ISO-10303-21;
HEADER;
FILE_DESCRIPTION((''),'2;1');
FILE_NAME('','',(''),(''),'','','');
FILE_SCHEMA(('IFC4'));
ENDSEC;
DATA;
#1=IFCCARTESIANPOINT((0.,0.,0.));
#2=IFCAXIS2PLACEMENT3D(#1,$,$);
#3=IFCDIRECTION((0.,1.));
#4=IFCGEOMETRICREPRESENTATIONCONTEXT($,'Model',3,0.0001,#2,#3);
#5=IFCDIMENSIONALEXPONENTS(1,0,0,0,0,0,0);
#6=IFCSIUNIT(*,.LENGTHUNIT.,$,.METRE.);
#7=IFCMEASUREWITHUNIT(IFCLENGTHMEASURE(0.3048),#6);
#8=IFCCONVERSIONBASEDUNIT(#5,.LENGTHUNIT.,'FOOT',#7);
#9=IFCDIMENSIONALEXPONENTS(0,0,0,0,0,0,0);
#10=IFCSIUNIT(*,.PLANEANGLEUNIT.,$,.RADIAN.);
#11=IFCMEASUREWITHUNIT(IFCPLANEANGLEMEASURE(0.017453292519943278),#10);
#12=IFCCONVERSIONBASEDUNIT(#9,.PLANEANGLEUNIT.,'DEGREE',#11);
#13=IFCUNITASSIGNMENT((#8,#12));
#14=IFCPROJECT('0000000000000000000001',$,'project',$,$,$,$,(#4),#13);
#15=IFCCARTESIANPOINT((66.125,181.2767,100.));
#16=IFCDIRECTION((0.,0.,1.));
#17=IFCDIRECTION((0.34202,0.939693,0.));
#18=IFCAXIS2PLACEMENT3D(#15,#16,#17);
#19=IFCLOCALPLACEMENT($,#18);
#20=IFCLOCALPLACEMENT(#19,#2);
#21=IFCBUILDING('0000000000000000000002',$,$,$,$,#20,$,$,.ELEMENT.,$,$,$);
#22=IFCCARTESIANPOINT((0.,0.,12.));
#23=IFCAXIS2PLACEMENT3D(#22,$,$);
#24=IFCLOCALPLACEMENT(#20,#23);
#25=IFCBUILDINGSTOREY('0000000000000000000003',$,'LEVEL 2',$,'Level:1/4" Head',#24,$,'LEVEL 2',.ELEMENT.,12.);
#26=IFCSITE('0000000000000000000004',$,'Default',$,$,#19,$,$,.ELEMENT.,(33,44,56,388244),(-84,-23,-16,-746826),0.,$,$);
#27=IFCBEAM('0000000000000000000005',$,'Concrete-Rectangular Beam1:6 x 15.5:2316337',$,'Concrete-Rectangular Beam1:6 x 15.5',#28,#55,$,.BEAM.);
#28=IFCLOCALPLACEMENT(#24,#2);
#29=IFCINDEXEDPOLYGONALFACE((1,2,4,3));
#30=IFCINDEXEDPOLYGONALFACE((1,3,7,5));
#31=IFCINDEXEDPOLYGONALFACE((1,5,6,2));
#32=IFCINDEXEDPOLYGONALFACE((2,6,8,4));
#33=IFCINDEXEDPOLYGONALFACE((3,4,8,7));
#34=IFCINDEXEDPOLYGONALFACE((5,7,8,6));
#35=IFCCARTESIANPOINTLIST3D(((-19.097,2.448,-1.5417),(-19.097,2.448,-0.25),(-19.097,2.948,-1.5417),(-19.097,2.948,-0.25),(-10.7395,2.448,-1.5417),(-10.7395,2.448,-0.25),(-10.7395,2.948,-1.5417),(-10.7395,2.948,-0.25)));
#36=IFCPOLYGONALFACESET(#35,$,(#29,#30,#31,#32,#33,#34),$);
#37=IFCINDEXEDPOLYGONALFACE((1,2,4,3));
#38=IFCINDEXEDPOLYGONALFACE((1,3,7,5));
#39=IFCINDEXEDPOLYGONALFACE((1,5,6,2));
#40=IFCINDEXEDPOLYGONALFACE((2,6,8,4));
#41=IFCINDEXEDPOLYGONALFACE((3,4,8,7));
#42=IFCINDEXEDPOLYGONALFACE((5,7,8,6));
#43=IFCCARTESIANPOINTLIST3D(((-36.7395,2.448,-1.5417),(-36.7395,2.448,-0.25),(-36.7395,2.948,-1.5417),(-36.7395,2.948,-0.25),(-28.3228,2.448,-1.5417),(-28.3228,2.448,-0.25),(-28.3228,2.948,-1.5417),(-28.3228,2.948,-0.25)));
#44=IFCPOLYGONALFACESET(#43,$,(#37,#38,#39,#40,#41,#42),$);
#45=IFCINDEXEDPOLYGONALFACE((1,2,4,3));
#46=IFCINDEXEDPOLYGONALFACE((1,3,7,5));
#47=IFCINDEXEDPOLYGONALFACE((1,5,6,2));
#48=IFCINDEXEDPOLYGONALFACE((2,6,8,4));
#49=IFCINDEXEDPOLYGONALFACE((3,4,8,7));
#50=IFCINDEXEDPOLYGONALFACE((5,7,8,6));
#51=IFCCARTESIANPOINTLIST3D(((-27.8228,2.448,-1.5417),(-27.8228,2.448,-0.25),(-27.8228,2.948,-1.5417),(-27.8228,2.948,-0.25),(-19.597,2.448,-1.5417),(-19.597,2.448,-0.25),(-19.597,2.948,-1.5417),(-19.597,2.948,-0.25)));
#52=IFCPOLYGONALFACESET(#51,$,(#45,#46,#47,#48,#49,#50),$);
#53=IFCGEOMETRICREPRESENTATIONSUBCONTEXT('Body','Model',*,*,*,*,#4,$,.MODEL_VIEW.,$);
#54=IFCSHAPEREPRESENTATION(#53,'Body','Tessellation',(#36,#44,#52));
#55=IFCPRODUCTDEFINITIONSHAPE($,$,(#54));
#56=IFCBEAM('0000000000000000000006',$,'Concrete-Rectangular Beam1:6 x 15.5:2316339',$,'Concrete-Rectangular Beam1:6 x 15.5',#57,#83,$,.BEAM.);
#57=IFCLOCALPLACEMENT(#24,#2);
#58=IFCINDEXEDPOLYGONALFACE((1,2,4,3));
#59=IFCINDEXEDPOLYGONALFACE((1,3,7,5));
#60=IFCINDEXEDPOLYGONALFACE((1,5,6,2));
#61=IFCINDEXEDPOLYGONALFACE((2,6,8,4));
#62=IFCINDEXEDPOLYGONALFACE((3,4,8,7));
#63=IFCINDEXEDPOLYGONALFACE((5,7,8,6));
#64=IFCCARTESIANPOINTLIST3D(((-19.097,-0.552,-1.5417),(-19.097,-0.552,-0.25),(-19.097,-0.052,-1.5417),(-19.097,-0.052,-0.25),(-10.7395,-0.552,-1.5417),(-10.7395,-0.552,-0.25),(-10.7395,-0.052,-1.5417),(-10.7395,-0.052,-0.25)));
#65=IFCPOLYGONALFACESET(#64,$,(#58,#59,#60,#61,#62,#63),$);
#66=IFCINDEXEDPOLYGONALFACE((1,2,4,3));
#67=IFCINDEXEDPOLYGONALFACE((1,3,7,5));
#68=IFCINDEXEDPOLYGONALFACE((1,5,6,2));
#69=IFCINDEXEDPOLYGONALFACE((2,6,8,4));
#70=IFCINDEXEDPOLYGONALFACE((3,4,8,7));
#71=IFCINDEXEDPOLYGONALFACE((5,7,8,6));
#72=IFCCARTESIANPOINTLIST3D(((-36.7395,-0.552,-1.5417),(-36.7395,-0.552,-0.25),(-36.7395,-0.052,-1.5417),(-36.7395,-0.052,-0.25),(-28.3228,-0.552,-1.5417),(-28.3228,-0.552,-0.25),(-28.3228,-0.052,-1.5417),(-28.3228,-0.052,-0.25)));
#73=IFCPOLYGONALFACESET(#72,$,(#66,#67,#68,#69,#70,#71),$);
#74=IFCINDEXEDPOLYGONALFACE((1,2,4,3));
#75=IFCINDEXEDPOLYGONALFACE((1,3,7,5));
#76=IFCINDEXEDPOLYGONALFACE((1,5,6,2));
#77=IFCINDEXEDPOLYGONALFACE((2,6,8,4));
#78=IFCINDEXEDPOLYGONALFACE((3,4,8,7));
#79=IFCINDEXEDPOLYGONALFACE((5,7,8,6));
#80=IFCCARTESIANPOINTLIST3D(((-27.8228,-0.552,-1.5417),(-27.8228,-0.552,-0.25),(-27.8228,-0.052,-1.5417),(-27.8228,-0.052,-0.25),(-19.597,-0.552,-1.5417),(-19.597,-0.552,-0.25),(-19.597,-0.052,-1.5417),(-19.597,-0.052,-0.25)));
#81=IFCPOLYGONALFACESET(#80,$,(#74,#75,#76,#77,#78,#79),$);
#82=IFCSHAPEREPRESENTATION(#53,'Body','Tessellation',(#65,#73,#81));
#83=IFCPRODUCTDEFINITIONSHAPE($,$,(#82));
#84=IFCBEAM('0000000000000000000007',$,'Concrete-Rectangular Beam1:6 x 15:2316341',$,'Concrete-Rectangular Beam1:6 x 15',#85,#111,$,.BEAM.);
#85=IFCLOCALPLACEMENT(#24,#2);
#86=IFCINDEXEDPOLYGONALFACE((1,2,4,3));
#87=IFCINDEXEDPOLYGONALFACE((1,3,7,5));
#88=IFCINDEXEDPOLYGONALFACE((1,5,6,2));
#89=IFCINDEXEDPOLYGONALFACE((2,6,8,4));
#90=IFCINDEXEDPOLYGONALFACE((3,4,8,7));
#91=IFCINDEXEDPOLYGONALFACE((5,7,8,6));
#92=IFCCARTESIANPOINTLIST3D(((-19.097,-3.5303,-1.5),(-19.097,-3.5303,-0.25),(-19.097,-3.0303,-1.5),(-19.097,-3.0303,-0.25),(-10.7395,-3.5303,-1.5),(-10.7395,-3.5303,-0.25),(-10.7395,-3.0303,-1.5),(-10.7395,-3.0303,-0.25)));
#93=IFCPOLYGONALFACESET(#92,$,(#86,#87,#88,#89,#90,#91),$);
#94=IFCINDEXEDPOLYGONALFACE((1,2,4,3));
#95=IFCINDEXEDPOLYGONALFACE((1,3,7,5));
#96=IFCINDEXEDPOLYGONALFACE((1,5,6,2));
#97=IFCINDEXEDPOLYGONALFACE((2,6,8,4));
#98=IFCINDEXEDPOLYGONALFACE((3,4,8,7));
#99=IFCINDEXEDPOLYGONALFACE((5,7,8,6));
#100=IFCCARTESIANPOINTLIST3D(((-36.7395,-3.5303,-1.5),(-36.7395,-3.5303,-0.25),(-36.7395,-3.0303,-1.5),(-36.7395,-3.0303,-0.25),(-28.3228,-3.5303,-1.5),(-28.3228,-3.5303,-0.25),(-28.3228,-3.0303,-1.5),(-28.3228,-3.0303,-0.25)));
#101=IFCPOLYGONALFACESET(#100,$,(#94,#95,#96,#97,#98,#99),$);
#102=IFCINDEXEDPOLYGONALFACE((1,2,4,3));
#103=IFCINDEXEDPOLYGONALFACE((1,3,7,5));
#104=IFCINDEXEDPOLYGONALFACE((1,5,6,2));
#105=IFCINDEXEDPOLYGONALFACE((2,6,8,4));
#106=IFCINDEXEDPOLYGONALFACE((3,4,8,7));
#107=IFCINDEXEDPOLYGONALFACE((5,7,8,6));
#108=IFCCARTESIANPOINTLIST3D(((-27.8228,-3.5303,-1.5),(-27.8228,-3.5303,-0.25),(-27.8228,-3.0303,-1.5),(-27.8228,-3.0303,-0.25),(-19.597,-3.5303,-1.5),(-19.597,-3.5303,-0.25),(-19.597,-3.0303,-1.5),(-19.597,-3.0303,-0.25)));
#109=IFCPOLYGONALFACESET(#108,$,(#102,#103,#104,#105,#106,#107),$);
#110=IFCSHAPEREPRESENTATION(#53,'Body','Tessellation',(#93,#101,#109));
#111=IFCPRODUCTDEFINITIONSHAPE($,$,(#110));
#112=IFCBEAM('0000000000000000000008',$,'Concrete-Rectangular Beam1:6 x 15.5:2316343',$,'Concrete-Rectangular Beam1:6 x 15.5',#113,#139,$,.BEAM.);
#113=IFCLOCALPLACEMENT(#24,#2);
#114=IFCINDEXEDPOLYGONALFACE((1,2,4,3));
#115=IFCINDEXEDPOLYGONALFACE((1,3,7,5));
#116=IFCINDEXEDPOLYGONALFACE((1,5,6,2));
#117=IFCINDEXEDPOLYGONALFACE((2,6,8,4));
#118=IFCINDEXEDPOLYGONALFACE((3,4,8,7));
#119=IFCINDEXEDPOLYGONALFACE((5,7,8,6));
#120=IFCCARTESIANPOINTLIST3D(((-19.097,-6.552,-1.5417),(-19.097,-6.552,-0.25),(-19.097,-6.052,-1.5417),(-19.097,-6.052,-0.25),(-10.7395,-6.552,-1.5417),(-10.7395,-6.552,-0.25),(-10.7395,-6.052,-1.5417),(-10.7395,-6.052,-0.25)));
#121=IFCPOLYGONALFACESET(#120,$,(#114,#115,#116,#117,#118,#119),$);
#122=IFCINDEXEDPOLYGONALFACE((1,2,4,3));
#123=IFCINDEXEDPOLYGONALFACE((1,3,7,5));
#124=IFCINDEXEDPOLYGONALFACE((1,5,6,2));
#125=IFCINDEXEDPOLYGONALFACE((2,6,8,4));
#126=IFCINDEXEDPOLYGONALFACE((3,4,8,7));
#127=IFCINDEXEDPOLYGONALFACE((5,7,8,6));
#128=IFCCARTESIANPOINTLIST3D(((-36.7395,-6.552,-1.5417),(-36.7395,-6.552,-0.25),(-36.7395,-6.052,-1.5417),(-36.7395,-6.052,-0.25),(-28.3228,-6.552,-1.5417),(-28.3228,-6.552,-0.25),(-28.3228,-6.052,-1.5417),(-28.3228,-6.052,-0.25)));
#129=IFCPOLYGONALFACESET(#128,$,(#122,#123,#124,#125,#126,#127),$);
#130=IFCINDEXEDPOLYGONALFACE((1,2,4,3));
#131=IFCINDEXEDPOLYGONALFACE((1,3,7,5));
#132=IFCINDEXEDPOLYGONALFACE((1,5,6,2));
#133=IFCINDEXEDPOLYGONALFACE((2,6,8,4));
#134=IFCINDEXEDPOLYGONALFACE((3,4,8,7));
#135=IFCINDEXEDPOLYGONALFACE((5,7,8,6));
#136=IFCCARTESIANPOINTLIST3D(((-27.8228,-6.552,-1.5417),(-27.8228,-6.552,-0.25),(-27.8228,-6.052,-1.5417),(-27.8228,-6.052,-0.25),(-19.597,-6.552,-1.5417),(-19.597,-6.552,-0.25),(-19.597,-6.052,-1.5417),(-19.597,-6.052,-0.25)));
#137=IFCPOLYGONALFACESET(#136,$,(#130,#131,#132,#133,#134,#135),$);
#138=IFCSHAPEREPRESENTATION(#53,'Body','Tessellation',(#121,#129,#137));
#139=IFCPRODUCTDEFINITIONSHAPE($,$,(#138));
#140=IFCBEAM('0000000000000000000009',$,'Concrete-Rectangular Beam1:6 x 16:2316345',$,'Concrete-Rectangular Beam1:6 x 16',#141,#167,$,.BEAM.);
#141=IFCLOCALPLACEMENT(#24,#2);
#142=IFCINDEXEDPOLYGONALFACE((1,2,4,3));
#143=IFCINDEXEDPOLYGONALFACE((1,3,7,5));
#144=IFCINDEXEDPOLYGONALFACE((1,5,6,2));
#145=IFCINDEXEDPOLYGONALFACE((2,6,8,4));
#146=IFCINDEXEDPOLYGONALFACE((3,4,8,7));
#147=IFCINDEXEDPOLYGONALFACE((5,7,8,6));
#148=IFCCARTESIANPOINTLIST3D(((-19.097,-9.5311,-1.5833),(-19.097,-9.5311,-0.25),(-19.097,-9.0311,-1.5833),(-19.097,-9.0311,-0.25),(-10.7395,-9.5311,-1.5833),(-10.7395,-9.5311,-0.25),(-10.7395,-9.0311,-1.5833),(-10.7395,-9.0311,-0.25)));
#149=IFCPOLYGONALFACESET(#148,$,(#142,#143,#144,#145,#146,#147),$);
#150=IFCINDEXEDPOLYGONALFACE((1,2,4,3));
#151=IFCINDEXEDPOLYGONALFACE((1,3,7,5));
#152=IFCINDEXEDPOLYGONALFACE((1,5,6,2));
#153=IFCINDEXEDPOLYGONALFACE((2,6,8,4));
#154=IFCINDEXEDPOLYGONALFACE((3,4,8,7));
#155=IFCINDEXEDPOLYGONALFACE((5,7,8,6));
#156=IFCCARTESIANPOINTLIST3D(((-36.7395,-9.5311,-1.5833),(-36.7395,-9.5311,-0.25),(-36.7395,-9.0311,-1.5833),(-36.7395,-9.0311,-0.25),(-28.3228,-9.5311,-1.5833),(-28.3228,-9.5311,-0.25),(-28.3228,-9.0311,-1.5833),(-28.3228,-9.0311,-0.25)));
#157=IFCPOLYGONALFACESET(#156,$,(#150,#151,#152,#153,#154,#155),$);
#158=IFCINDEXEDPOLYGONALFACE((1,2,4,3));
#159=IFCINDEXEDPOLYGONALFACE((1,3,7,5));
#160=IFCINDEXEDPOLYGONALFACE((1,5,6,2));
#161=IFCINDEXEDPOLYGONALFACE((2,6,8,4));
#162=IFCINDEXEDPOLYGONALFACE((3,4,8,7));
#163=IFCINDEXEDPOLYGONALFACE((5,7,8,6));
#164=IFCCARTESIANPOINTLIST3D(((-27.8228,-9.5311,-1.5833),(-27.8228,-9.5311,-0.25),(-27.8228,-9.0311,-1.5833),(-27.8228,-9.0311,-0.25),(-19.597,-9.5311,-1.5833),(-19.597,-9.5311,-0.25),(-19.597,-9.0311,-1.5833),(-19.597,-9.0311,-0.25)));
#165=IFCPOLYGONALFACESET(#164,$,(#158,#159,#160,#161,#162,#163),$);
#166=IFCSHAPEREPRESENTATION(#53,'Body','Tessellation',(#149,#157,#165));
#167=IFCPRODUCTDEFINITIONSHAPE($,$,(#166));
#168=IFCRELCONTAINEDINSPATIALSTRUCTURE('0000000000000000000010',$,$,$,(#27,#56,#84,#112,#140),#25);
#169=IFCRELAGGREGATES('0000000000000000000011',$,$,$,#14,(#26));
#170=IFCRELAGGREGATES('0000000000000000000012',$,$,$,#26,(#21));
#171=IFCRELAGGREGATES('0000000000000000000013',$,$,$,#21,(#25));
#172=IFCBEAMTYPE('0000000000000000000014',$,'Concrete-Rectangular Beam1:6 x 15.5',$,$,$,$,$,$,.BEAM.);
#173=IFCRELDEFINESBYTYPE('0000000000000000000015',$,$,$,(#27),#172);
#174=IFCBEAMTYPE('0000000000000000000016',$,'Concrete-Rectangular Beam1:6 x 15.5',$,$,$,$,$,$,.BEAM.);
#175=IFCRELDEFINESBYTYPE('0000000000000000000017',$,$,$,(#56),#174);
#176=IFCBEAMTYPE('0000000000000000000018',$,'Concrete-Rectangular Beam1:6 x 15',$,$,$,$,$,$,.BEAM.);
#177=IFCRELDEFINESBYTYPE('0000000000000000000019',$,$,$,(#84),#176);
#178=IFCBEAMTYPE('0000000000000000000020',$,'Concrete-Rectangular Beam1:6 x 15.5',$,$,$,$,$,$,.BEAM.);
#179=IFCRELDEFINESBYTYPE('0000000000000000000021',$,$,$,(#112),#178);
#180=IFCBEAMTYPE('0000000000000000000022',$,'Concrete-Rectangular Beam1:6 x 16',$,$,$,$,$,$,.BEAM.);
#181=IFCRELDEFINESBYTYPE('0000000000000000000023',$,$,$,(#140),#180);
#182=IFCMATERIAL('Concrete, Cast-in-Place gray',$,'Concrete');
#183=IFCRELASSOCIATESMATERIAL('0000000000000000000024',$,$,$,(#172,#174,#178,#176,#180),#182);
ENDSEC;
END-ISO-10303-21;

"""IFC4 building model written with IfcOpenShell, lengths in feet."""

from ifc_helpers import new_model, entity, si_unit, converted_unit, direction, frame, frame_2d, origin, origin_2d_with_axis, place, context, subcontext, project, spatial, polyline, segment, composite_curve, rectangle, outline, extrude, source, transform, mapped, material, material_profile, profile_set, type_object, type_shapes, element, save


model = new_model("IFC4")

# Units and contexts
model_context = context("Model", 3, precision=0.0001, world=origin(), true_north=direction((0.0, 1.0)))
body_context = subcontext(model_context, "Body", "Model", "MODEL_VIEW")
ifc_project = project(units=[converted_unit("LENGTHUNIT", "FOOT", entity("IfcLengthMeasure", 0.3048), si_unit("LENGTHUNIT", "METRE"), dimensions=[1, 0, 0, 0, 0, 0, 0]), converted_unit("PLANEANGLEUNIT", "DEGREE", entity("IfcPlaneAngleMeasure", 0.017453292519943278), si_unit("PLANEANGLEUNIT", "RADIAN"), dimensions=[0, 0, 0, 0, 0, 0, 0])], contexts=[model_context])

# Site, building, storey
site_placement = place(None, frame((66.125, 181.2767, 100.0), z_axis=(0.0, 0.0, 1.0), x_axis=(0.34202, 0.939693, 0.0)))
site = spatial("IfcSite", under=ifc_project, at=site_placement, Name="Default", CompositionType="ELEMENT", RefLatitude=(33, 44, 56, 388244), RefLongitude=(-84, -23, -16, -746826), RefElevation=0.0)
building_placement = place(site_placement, origin())
building = spatial("IfcBuilding", under=site, at=building_placement, CompositionType="ELEMENT")
storey_placement = place(building_placement, frame((0.0, 0.0, 12.0)))
storey = spatial("IfcBuildingStorey", under=building, at=storey_placement, Name="LEVEL 2", ObjectType="Level:1/4\" Head", LongName="LEVEL 2", CompositionType="ELEMENT", Elevation=12.0)

# Beams
ifc_material = material(Name="Concrete, Cast-in-Place gray", Category="Concrete")
ifc_material_profile_1 = material_profile(ifc_material, rectangle(XDim=1.3333, YDim=0.5, at=frame_2d((0.0, 0.0), x_axis=(1.0, 0.0))), Name="6 x 16")
ifc_profile_set_1 = profile_set([ifc_material_profile_1], Name="6 x 16")
ifc_material_profile_2 = material_profile(ifc_material, outline(composite_curve([segment(polyline([(-0.25, 0.6458, 0.0), (0.25, 0.6458, 0.0)]), True, "CONTINUOUS"), segment(polyline([(0.25, 0.6458, 0.0), (0.25, -0.6458, 0.0)]), True, "CONTINUOUS"), segment(polyline([(0.25, -0.6458, 0.0), (-0.25, -0.6458, 0.0)]), True, "CONTINUOUS"), segment(polyline([(-0.25, -0.6458, 0.0), (-0.25, 0.6458, 0.0)]), True, "CONTINUOUS")], self_intersect=False), kind="CURVE"), Name="6 x 15.5")
ifc_material_profile_3 = material_profile(ifc_material, outline(composite_curve([segment(polyline([(-12.5417, 0.25, 0.6458), (-12.5417, 0.25, -0.6458)]), True, "CONTINUOUS"), segment(polyline([(-12.5417, 0.25, -0.6458), (-12.5417, -0.25, -0.6458)]), True, "CONTINUOUS"), segment(polyline([(-12.5417, -0.25, -0.6458), (-12.5417, -0.25, 0.6458)]), True, "CONTINUOUS"), segment(polyline([(-12.5417, -0.25, 0.6458), (-12.5417, 0.25, 0.6458)]), True, "CONTINUOUS")], self_intersect=False), kind="CURVE"), Name="6 x 15.5")
ifc_profile_set_2 = profile_set([ifc_material_profile_2, ifc_material_profile_3], Name="6 x 15.5")
beam_type_1 = type_object("IfcBeamType", Name="Concrete-Rectangular Beam1:6 x 15.5", PredefinedType="BEAM", material=ifc_profile_set_2)
shared_shape_1 = source(origin(), body_context, "Body", "SweptSolid", [
    extrude(rectangle(XDim=1.2917, YDim=0.5, at=frame_2d((0.0, 0.0), x_axis=(1.0, 0.0))), frame((-19.097, 2.698, 11.1042), z_axis=(1.0, 0.0, 0.0), x_axis=(0.0, 0.0, -1.0)), (0.0, 0.0, 1.0), 8.3575),
    extrude(rectangle(XDim=1.2917, YDim=0.5, at=frame_2d((0.0, 0.0), x_axis=(1.0, 0.0))), frame((-36.7395, 2.698, 11.1042), z_axis=(1.0, 0.0, 0.0), x_axis=(0.0, 0.0, -1.0)), (0.0, 0.0, 1.0), 8.4167),
    extrude(rectangle(XDim=1.2917, YDim=0.5, at=frame_2d((0.0, 0.0), x_axis=(1.0, 0.0))), frame((-27.8228, 2.698, 11.1042), z_axis=(1.0, 0.0, 0.0), x_axis=(0.0, 0.0, -1.0)), (0.0, 0.0, 1.0), 8.2258),
])
type_shapes(beam_type_1, [shared_shape_1])
beam_1_placement = place(storey_placement, frame((0.0, 0.0, -12.0)))
element("IfcBeam", 1, at=beam_1_placement, inside=storey, type_object=beam_type_1, Name="Concrete-Rectangular Beam1:6 x 15.5:2316337", ObjectType="Concrete-Rectangular Beam1:6 x 15.5", PredefinedType="BEAM", context=body_context, shape_type="MappedRepresentation", body=[
    mapped(shared_shape_1, transform((0.0, 0.0, 0.0), scale=1.0)),
])
beam_type_2 = type_object("IfcBeamType", Name="Concrete-Rectangular Beam1:6 x 15.5", PredefinedType="BEAM", material=ifc_profile_set_2)
shared_shape_2 = source(origin(), body_context, "Body", "SweptSolid", [
    extrude(rectangle(XDim=1.2917, YDim=0.5, at=frame_2d((0.0, 0.0), x_axis=(1.0, 0.0))), frame((-19.097, -0.302, 11.1042), z_axis=(1.0, 0.0, 0.0), x_axis=(0.0, 0.0, -1.0)), (0.0, 0.0, 1.0), 8.3575),
    extrude(rectangle(XDim=1.2917, YDim=0.5, at=frame_2d((0.0, 0.0), x_axis=(1.0, 0.0))), frame((-36.7395, -0.302, 11.1042), z_axis=(1.0, 0.0, 0.0), x_axis=(0.0, 0.0, -1.0)), (0.0, 0.0, 1.0), 8.4167),
    extrude(rectangle(XDim=1.2917, YDim=0.5, at=frame_2d((0.0, 0.0), x_axis=(1.0, 0.0))), frame((-27.8228, -0.302, 11.1042), z_axis=(1.0, 0.0, 0.0), x_axis=(0.0, 0.0, -1.0)), (0.0, 0.0, 1.0), 8.2258),
])
type_shapes(beam_type_2, [shared_shape_2])
beam_2_placement = place(storey_placement, frame((0.0, 0.0, -12.0)))
element("IfcBeam", 2, at=beam_2_placement, inside=storey, type_object=beam_type_2, Name="Concrete-Rectangular Beam1:6 x 15.5:2316339", ObjectType="Concrete-Rectangular Beam1:6 x 15.5", PredefinedType="BEAM", context=body_context, shape_type="MappedRepresentation", body=[
    mapped(shared_shape_2, transform((0.0, 0.0, 0.0), scale=1.0)),
])
ifc_material_profile_4 = material_profile(ifc_material, rectangle(XDim=1.25, YDim=0.5, at=origin_2d_with_axis()), Name="6 x 15")
ifc_profile_set_3 = profile_set([ifc_material_profile_4], Name="6 x 15")
beam_type_3 = type_object("IfcBeamType", Name="Concrete-Rectangular Beam1:6 x 15", PredefinedType="BEAM", material=ifc_profile_set_3)
shared_shape_3 = source(origin(), body_context, "Body", "SweptSolid", [
    extrude(rectangle(XDim=1.25, YDim=0.5, at=origin_2d_with_axis()), frame((-19.097, -3.2803, 11.125), z_axis=(1.0, 0.0, 0.0), x_axis=(0.0, 0.0, -1.0)), (0.0, 0.0, 1.0), 8.3575),
    extrude(rectangle(XDim=1.25, YDim=0.5, at=origin_2d_with_axis()), frame((-36.7395, -3.2803, 11.125), z_axis=(1.0, 0.0, 0.0), x_axis=(0.0, 0.0, -1.0)), (0.0, 0.0, 1.0), 8.4167),
    extrude(rectangle(XDim=1.25, YDim=0.5, at=origin_2d_with_axis()), frame((-27.8228, -3.2803, 11.125), z_axis=(1.0, 0.0, 0.0), x_axis=(0.0, 0.0, -1.0)), (0.0, 0.0, 1.0), 8.2258),
])
type_shapes(beam_type_3, [shared_shape_3])
beam_3_placement = place(storey_placement, frame((0.0, 0.0, -12.0)))
element("IfcBeam", 3, at=beam_3_placement, inside=storey, type_object=beam_type_3, Name="Concrete-Rectangular Beam1:6 x 15:2316341", ObjectType="Concrete-Rectangular Beam1:6 x 15", PredefinedType="BEAM", context=body_context, shape_type="MappedRepresentation", body=[
    mapped(shared_shape_3, transform((0.0, 0.0, 0.0), scale=1.0)),
])
beam_type_4 = type_object("IfcBeamType", Name="Concrete-Rectangular Beam1:6 x 15.5", PredefinedType="BEAM", material=ifc_profile_set_2)
shared_shape_4 = source(origin(), body_context, "Body", "SweptSolid", [
    extrude(rectangle(XDim=1.2917, YDim=0.5, at=frame_2d((0.0, 0.0), x_axis=(1.0, 0.0))), frame((-19.097, -6.302, 11.1042), z_axis=(1.0, 0.0, 0.0), x_axis=(0.0, 0.0, -1.0)), (0.0, 0.0, 1.0), 8.3575),
    extrude(rectangle(XDim=1.2917, YDim=0.5, at=frame_2d((0.0, 0.0), x_axis=(1.0, 0.0))), frame((-36.7395, -6.302, 11.1042), z_axis=(1.0, 0.0, 0.0), x_axis=(0.0, 0.0, -1.0)), (0.0, 0.0, 1.0), 8.4167),
    extrude(rectangle(XDim=1.2917, YDim=0.5, at=frame_2d((0.0, 0.0), x_axis=(1.0, 0.0))), frame((-27.8228, -6.302, 11.1042), z_axis=(1.0, 0.0, 0.0), x_axis=(0.0, 0.0, -1.0)), (0.0, 0.0, 1.0), 8.2258),
])
type_shapes(beam_type_4, [shared_shape_4])
beam_4_placement = place(storey_placement, frame((0.0, 0.0, -12.0)))
element("IfcBeam", 4, at=beam_4_placement, inside=storey, type_object=beam_type_4, Name="Concrete-Rectangular Beam1:6 x 15.5:2316343", ObjectType="Concrete-Rectangular Beam1:6 x 15.5", PredefinedType="BEAM", context=body_context, shape_type="MappedRepresentation", body=[
    mapped(shared_shape_4, transform((0.0, 0.0, 0.0), scale=1.0)),
])
beam_type_5 = type_object("IfcBeamType", Name="Concrete-Rectangular Beam1:6 x 16", PredefinedType="BEAM", material=ifc_profile_set_1)
shared_shape_5 = source(origin(), body_context, "Body", "SweptSolid", [
    extrude(rectangle(XDim=1.3333, YDim=0.5, at=frame_2d((0.0, 0.0), x_axis=(1.0, 0.0))), frame((-19.097, -9.2811, 11.0833), z_axis=(1.0, 0.0, 0.0), x_axis=(0.0, 0.0, -1.0)), (0.0, 0.0, 1.0), 8.3575),
    extrude(rectangle(XDim=1.3333, YDim=0.5, at=frame_2d((0.0, 0.0), x_axis=(1.0, 0.0))), frame((-36.7395, -9.2811, 11.0833), z_axis=(1.0, 0.0, 0.0), x_axis=(0.0, 0.0, -1.0)), (0.0, 0.0, 1.0), 8.4167),
    extrude(rectangle(XDim=1.3333, YDim=0.5, at=frame_2d((0.0, 0.0), x_axis=(1.0, 0.0))), frame((-27.8228, -9.2811, 11.0833), z_axis=(1.0, 0.0, 0.0), x_axis=(0.0, 0.0, -1.0)), (0.0, 0.0, 1.0), 8.2258),
])
type_shapes(beam_type_5, [shared_shape_5])
beam_5_placement = place(storey_placement, frame((0.0, 0.0, -12.0)))
element("IfcBeam", 5, at=beam_5_placement, inside=storey, type_object=beam_type_5, Name="Concrete-Rectangular Beam1:6 x 16:2316345", ObjectType="Concrete-Rectangular Beam1:6 x 16", PredefinedType="BEAM", context=body_context, shape_type="MappedRepresentation", body=[
    mapped(shared_shape_5, transform((0.0, 0.0, 0.0), scale=1.0)),
])

save(model, "model.ifc")
